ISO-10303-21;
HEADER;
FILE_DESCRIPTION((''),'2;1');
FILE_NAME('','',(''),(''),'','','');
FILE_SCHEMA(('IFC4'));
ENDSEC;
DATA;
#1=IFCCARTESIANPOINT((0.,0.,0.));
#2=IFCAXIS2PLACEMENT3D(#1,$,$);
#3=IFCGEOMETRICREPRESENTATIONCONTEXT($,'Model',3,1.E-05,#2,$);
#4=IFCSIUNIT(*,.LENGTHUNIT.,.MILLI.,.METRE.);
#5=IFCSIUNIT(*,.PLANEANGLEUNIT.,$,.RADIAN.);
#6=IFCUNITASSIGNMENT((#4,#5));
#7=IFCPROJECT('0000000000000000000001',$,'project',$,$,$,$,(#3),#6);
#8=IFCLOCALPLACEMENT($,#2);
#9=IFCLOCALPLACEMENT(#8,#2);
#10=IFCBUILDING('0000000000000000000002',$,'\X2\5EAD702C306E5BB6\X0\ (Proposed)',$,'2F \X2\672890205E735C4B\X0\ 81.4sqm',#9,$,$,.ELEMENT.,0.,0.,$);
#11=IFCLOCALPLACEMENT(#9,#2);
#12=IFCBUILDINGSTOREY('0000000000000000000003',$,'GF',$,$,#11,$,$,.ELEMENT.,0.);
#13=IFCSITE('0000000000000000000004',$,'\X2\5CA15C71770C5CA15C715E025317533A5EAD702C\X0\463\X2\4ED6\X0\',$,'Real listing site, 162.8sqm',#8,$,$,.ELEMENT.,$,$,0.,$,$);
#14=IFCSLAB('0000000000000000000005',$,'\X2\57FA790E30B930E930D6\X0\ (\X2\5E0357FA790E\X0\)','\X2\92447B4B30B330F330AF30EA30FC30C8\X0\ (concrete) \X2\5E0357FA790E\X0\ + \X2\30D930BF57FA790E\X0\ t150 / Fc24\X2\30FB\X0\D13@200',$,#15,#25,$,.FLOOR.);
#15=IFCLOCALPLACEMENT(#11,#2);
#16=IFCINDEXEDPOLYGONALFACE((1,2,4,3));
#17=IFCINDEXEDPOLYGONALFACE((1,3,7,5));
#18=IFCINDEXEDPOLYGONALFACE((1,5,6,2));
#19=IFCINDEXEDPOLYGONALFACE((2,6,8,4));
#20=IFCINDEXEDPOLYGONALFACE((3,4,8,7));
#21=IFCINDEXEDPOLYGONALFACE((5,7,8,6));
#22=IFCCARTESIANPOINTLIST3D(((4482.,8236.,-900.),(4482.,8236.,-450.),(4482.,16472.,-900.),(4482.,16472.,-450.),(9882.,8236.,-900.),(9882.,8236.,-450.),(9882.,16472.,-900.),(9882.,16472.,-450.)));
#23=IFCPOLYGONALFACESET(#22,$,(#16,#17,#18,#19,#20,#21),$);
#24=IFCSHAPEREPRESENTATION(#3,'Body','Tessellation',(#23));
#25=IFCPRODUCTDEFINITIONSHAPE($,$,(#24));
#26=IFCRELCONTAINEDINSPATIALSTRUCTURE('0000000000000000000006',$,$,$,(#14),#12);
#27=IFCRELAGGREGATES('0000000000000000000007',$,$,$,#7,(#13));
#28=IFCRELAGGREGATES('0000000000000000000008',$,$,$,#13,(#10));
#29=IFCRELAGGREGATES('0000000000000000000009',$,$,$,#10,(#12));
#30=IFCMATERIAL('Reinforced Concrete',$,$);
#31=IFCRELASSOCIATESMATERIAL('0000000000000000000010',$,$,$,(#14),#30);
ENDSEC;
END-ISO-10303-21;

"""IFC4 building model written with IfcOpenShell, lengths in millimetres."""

from ifc_helpers import new_model, si_unit, frame, frame_2d, origin, place, context, project, spatial, rectangle, extrude, material, element, save


model = new_model("IFC4")

# Units and contexts
model_context = context("Model", 3, precision=1e-05, world=origin())
ifc_project = project(units=[si_unit("LENGTHUNIT", "METRE", prefix="MILLI"), si_unit("PLANEANGLEUNIT", "RADIAN")], contexts=[model_context])

# Site, building, storey
site_placement = place(None, origin())
site = spatial("IfcSite", under=ifc_project, at=site_placement, Name="岡山県岡山市北区庭瀬463他", ObjectType="Real listing site, 162.8sqm", CompositionType="ELEMENT", RefElevation=0.0)
building_placement = place(site_placement, origin())
building = spatial("IfcBuilding", under=site, at=building_placement, Name="庭瀬の家 (Proposed)", ObjectType="2F 木造平屋 81.4sqm", CompositionType="ELEMENT", ElevationOfRefHeight=0.0, ElevationOfTerrain=0.0)
storey_placement = place(building_placement, origin())
storey = spatial("IfcBuildingStorey", under=building, at=storey_placement, Name="GF", CompositionType="ELEMENT", Elevation=0.0)

# Slab
ifc_material_1 = material(Name="Reinforced Concrete")
slab_1_placement = place(storey_placement, frame((2241.0, 4118.0, -450.0)))
element("IfcSlab", 1, at=slab_1_placement, inside=storey, material=ifc_material_1, Name="基礎スラブ (布基礎)", Description="鉄筋コンクリート (concrete) 布基礎 + ベタ基礎 t150 / Fc24・D13@200", PredefinedType="FLOOR", context=model_context, shape_type="SweptSolid", body=[
    extrude(rectangle(XDim=5400.0, YDim=8236.0, at=frame_2d((2700.0, 4118.0))), frame((2241.0, 4118.0, -450.0)), (0.0, 0.0, 1.0), 450.0),
])

save(model, "model.ifc")
